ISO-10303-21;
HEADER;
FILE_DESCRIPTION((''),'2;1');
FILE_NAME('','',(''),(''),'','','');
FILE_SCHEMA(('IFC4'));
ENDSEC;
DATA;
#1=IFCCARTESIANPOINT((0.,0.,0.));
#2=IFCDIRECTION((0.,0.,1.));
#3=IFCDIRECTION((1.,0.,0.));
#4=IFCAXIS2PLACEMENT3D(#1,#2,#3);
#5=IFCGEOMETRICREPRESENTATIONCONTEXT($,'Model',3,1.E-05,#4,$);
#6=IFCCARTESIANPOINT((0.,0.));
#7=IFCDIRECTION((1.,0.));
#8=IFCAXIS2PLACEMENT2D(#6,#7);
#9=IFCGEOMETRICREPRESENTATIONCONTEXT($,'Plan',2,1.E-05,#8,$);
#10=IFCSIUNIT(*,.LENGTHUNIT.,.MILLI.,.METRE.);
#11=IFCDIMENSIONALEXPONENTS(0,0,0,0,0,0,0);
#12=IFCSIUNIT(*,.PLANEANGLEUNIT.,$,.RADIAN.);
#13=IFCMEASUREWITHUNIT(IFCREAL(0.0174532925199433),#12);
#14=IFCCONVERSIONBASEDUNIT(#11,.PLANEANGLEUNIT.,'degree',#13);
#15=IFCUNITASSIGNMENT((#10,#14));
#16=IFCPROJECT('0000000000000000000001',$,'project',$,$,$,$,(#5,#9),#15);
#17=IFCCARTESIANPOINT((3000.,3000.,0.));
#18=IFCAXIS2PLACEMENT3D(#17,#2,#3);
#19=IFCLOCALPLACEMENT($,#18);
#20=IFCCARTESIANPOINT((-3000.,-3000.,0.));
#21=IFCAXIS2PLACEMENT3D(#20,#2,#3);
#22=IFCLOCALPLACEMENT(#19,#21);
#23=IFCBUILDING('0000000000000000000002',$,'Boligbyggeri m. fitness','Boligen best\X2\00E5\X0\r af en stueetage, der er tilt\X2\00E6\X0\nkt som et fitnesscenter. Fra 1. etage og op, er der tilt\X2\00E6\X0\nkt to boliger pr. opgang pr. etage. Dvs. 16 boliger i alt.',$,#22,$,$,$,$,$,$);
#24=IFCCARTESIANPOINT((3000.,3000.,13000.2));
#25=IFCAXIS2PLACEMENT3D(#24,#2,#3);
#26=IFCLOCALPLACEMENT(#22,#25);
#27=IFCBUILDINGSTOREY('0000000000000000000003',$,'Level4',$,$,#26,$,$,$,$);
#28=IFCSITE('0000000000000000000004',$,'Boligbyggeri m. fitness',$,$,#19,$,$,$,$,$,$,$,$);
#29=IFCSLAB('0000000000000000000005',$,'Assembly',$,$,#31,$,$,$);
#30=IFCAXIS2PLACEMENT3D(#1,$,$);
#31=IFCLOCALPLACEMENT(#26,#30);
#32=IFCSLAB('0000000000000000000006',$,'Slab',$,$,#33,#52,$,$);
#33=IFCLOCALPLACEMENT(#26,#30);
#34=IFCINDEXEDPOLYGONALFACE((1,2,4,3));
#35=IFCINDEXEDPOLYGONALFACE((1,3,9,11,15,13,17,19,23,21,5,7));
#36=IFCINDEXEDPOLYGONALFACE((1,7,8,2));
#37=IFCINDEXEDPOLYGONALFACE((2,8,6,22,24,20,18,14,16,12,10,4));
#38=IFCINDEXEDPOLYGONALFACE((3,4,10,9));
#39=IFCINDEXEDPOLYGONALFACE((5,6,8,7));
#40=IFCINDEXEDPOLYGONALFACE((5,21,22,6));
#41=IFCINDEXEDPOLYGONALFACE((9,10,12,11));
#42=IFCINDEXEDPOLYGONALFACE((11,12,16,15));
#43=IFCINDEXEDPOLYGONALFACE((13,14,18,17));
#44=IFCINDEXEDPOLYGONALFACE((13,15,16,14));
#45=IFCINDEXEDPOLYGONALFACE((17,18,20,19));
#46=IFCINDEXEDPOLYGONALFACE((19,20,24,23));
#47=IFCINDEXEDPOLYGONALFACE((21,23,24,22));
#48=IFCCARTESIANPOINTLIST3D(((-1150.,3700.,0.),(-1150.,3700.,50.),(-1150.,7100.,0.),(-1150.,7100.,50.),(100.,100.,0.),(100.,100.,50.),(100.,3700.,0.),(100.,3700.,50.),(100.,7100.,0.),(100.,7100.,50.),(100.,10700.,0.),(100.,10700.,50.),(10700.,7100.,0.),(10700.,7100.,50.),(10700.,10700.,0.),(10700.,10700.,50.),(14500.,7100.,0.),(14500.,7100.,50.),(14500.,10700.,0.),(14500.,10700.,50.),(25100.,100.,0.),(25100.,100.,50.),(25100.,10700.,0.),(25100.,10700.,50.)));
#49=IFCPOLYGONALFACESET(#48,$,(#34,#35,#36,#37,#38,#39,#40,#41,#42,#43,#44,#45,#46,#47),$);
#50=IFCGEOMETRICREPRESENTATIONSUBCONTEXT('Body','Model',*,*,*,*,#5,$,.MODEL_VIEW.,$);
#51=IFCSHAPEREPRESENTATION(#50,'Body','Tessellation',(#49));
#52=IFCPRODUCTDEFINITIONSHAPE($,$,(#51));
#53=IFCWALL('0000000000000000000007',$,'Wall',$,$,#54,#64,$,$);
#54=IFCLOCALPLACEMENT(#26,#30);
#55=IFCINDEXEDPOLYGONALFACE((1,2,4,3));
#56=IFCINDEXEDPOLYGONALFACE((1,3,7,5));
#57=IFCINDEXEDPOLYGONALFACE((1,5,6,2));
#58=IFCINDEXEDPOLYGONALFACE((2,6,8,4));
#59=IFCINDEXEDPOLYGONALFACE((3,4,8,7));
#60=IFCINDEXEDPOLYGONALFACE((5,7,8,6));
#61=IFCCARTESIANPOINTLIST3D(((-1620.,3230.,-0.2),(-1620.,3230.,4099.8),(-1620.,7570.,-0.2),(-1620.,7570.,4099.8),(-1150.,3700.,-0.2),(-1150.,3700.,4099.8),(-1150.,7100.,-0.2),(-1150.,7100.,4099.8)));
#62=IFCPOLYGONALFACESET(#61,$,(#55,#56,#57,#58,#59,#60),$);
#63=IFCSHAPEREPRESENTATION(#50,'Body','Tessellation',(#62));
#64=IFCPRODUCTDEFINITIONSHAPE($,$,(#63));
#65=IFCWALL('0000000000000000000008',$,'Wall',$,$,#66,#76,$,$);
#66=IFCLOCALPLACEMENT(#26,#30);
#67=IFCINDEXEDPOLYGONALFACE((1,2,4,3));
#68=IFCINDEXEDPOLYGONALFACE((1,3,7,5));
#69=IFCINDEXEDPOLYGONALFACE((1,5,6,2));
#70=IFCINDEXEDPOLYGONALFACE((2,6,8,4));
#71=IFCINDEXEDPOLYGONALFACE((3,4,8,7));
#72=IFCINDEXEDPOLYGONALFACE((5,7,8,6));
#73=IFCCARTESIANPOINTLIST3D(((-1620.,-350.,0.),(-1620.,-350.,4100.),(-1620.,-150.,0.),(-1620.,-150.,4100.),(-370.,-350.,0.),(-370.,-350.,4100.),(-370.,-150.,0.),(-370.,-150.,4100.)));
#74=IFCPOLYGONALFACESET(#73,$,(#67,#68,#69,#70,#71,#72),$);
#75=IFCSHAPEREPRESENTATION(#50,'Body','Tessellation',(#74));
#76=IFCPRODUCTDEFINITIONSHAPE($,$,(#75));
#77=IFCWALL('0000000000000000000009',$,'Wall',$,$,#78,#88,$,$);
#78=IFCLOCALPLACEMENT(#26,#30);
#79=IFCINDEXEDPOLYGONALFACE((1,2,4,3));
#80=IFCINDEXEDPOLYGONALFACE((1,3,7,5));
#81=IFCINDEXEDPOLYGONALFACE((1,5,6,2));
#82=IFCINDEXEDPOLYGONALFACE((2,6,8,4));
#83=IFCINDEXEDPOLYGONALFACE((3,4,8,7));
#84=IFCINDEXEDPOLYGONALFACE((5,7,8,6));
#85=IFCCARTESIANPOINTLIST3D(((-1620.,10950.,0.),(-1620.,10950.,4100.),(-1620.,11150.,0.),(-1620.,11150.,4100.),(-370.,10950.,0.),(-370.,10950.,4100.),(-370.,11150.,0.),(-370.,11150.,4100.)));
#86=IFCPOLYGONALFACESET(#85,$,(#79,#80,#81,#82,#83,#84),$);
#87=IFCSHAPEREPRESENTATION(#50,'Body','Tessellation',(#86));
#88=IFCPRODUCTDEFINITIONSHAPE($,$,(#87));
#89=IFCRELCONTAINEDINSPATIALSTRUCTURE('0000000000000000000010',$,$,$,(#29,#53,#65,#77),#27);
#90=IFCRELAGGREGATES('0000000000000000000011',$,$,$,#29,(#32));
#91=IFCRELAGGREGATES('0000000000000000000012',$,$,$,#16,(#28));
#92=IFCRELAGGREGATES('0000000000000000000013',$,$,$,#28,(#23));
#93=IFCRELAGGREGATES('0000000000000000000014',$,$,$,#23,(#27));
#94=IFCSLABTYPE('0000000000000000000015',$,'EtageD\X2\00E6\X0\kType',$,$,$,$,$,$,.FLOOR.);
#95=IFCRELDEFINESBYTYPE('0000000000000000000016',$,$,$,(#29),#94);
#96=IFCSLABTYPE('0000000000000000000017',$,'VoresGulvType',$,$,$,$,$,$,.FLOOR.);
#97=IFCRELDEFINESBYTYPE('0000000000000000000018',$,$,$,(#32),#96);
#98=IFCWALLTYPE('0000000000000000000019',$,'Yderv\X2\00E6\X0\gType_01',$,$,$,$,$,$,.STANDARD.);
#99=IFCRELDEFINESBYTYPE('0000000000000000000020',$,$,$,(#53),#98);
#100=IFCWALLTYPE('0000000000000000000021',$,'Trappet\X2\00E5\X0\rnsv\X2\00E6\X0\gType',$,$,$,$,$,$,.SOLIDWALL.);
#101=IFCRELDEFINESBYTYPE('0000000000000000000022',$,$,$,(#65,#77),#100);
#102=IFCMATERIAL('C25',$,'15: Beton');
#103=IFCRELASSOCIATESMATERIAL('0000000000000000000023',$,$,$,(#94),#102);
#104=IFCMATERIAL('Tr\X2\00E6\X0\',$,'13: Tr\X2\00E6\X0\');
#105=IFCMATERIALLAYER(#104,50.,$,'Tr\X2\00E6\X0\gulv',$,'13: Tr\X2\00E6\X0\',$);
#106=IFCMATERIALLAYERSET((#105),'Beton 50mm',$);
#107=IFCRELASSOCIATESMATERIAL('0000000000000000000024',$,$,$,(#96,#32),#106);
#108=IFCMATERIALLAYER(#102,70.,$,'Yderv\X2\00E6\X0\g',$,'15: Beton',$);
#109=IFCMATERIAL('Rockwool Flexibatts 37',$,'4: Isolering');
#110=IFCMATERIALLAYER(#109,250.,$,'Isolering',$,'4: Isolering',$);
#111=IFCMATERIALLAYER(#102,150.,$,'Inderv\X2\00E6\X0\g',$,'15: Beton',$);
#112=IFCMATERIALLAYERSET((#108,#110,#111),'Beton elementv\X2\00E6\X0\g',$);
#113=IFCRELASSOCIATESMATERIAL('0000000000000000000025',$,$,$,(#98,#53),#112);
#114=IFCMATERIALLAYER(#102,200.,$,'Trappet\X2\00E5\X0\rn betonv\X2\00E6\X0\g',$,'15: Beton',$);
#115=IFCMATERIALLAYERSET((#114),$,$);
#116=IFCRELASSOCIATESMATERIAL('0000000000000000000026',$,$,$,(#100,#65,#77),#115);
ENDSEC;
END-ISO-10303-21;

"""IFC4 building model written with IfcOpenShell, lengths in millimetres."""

from ifc_helpers import new_model, entity, si_unit, converted_unit, frame, origin_with_axes, origin_2d_with_axis, place, context, subcontext, project, spatial, line, indexed_curve, outline, extrude, clip, halfspace, material, layer, layer_set, layer_usage, type_object, element, aggregate, save


model = new_model("IFC4")

# Units and contexts
model_context = context("Model", 3, precision=1e-05, world=origin_with_axes())
plan_context = context("Plan", 2, precision=1e-05, world=origin_2d_with_axis())
body_context = subcontext(model_context, "Body", "Model", "MODEL_VIEW")
ifc_project = project(units=[si_unit("LENGTHUNIT", "METRE", prefix="MILLI"), converted_unit("PLANEANGLEUNIT", "degree", entity("IfcReal", 0.0174532925199433), si_unit("PLANEANGLEUNIT", "RADIAN"), dimensions=[0, 0, 0, 0, 0, 0, 0])], contexts=[model_context, plan_context])

# Site, building, storey
site_placement = place(None, frame((3000.0, 3000.0, 0.0), z_axis=(0.0, 0.0, 1.0), x_axis=(1.0, 0.0, 0.0)))
site = spatial("IfcSite", under=ifc_project, at=site_placement, Name="Boligbyggeri m. fitness")
building_placement = place(site_placement, frame((-3000.0, -3000.0, 0.0), z_axis=(0.0, 0.0, 1.0), x_axis=(1.0, 0.0, 0.0)))
building = spatial("IfcBuilding", under=site, at=building_placement, Name="Boligbyggeri m. fitness", Description="Boligen består af en stueetage, der er tiltænkt som et fitnesscenter. Fra 1. etage og op, er der tiltænkt to boliger pr. opgang pr. etage. Dvs. 16 boliger i alt.")
storey_placement = place(building_placement, frame((3000.0, 3000.0, 13000.2), z_axis=(0.0, 0.0, 1.0), x_axis=(1.0, 0.0, 0.0)))
storey = spatial("IfcBuildingStorey", under=building, at=storey_placement, Name="Level4")

# Shared definitions
ifc_material_1 = material(Name="C25", Category="15: Beton")

# Slabs
slab_type_1 = type_object("IfcSlabType", Name="EtageDækType", PredefinedType="FLOOR", material=ifc_material_1)
slab_1_placement = place(storey_placement, frame((25300.0, 3700.0, -12999.9), z_axis=(0.0, 0.0, 1.0), x_axis=(1.0, 0.0, 0.0)))
slab_1 = element("IfcSlab", 1, at=slab_1_placement, inside=storey, type_object=slab_type_1, Name="Assembly")
ifc_material_2 = material(Name="Træ", Category="13: Træ")
ifc_layer_1 = layer(ifc_material_2, 50.0, Name="Trægulv", Category="13: Træ")
ifc_layer_set_1 = layer_set([ifc_layer_1], Name="Beton 50mm")
ifc_layer_usage_1 = layer_usage(ifc_layer_set_1, "AXIS3", "POSITIVE", 0.0)
slab_type_2 = type_object("IfcSlabType", Name="VoresGulvType", PredefinedType="FLOOR", material=ifc_layer_set_1)
slab_2_placement = place(slab_1_placement, frame((-25200.0, -3600.0, 12999.9), z_axis=(0.0, 0.0, 1.0), x_axis=(1.0, 0.0, 0.0)))
slab_2 = element("IfcSlab", 2, at=slab_2_placement, type_object=slab_type_2, material=ifc_layer_usage_1, Name="Slab", context=body_context, shape_type="SweptSolid", body=[
    extrude(outline(indexed_curve([(10600.0, 7000.0), (10600.0, 10600.0), (0.0, 10600.0), (0.0, 0.0), (25000.0, 0.0), (25000.0, 10600.0), (14400.0, 10600.0), (14400.0, 7000.0), (0.0, 7000.0), (0.0, 3600.0), (-1250.0, 3600.0), (-1250.0, 7000.0)], segments=[line(4, 5), line(5, 6), line(6, 7), line(7, 8), line(8, 1), line(1, 2), line(2, 3), line(3, 9), line(9, 12), line(12, 11), line(11, 10), line(10, 4)], self_intersect=False)), None, (0.0, 0.0, 1.0), 50.0),
])
aggregate(slab_1, [slab_2])

# Walls
ifc_layer_2 = layer(ifc_material_1, 70.0, Name="Ydervæg", Category="15: Beton")
ifc_material_3 = material(Name="Rockwool Flexibatts 37", Category="4: Isolering")
ifc_layer_3 = layer(ifc_material_3, 250.0, Name="Isolering", Category="4: Isolering")
ifc_layer_4 = layer(ifc_material_1, 150.0, Name="Indervæg", Category="15: Beton")
ifc_layer_set_2 = layer_set([ifc_layer_2, ifc_layer_3, ifc_layer_4], Name="Beton elementvæg")
ifc_layer_usage_2 = layer_usage(ifc_layer_set_2, "AXIS2", "POSITIVE", 0.0)
wall_type_1 = type_object("IfcWallType", Name="YdervægType_01", PredefinedType="STANDARD", material=ifc_layer_set_2)
wall_1_placement = place(storey_placement, frame((-1620.0, 7570.0, -0.2), z_axis=(0.0, 0.0, 1.0), x_axis=(0.0, -1.0, 0.0)))
element("IfcWall", 3, at=wall_1_placement, inside=storey, type_object=wall_type_1, material=ifc_layer_usage_2, Name="Wall", context=body_context, shape_type="Clipping", body=[
    clip(clip(extrude(outline(indexed_curve([(0.0, 0.0), (0.0, 470.0), (4340.0, 470.0), (4340.0, 0.0), (0.0, 0.0)], self_intersect=False)), origin_with_axes(), (0.0, 0.0, 1.0), 4100.0), halfspace(frame((0.0, 0.0, -13000.0), z_axis=(-0.707106, 0.707107, 0.0), x_axis=(0.707107, 0.707106, 0.0)), False)), halfspace(frame((4340.0, 0.0, -13000.0), z_axis=(0.707107, 0.707106, 0.0), x_axis=(0.707106, -0.707107, 0.0)), False)),
])
ifc_layer_5 = layer(ifc_material_1, 200.0, Name="Trappetårn betonvæg", Category="15: Beton")
ifc_layer_set_3 = layer_set([ifc_layer_5])
ifc_layer_usage_3 = layer_usage(ifc_layer_set_3, "AXIS2", "POSITIVE", 0.0)
wall_type_2 = type_object("IfcWallType", Name="TrappetårnsvægType", PredefinedType="SOLIDWALL", material=ifc_layer_set_3)
wall_2_placement = place(storey_placement, frame((-1620.0, -350.0, 0.0), z_axis=(0.0, 0.0, 1.0), x_axis=(1.0, 0.0, 0.0)))
element("IfcWall", 4, at=wall_2_placement, inside=storey, type_object=wall_type_2, material=ifc_layer_usage_3, Name="Wall", context=body_context, shape_type="SweptSolid", body=[
    extrude(outline(indexed_curve([(0.0, 0.0), (0.0, 200.0), (1250.0, 200.0), (1250.0, 0.0), (0.0, 0.0)], self_intersect=False)), origin_with_axes(), (0.0, 0.0, 1.0), 4100.0),
])
ifc_layer_usage_4 = layer_usage(ifc_layer_set_3, "AXIS2", "POSITIVE", 0.0)
wall_3_placement = place(storey_placement, frame((-370.0, 11150.0, 0.0), z_axis=(0.0, 0.0, 1.0), x_axis=(-1.0, 0.0, 0.0)))
element("IfcWall", 5, at=wall_3_placement, inside=storey, type_object=wall_type_2, material=ifc_layer_usage_4, Name="Wall", context=body_context, shape_type="SweptSolid", body=[
    extrude(outline(indexed_curve([(0.0, 0.0), (0.0, 200.0), (1250.0, 200.0), (1250.0, 0.0), (0.0, 0.0)], self_intersect=False)), origin_with_axes(), (0.0, 0.0, 1.0), 4100.0),
])

save(model, "model.ifc")
